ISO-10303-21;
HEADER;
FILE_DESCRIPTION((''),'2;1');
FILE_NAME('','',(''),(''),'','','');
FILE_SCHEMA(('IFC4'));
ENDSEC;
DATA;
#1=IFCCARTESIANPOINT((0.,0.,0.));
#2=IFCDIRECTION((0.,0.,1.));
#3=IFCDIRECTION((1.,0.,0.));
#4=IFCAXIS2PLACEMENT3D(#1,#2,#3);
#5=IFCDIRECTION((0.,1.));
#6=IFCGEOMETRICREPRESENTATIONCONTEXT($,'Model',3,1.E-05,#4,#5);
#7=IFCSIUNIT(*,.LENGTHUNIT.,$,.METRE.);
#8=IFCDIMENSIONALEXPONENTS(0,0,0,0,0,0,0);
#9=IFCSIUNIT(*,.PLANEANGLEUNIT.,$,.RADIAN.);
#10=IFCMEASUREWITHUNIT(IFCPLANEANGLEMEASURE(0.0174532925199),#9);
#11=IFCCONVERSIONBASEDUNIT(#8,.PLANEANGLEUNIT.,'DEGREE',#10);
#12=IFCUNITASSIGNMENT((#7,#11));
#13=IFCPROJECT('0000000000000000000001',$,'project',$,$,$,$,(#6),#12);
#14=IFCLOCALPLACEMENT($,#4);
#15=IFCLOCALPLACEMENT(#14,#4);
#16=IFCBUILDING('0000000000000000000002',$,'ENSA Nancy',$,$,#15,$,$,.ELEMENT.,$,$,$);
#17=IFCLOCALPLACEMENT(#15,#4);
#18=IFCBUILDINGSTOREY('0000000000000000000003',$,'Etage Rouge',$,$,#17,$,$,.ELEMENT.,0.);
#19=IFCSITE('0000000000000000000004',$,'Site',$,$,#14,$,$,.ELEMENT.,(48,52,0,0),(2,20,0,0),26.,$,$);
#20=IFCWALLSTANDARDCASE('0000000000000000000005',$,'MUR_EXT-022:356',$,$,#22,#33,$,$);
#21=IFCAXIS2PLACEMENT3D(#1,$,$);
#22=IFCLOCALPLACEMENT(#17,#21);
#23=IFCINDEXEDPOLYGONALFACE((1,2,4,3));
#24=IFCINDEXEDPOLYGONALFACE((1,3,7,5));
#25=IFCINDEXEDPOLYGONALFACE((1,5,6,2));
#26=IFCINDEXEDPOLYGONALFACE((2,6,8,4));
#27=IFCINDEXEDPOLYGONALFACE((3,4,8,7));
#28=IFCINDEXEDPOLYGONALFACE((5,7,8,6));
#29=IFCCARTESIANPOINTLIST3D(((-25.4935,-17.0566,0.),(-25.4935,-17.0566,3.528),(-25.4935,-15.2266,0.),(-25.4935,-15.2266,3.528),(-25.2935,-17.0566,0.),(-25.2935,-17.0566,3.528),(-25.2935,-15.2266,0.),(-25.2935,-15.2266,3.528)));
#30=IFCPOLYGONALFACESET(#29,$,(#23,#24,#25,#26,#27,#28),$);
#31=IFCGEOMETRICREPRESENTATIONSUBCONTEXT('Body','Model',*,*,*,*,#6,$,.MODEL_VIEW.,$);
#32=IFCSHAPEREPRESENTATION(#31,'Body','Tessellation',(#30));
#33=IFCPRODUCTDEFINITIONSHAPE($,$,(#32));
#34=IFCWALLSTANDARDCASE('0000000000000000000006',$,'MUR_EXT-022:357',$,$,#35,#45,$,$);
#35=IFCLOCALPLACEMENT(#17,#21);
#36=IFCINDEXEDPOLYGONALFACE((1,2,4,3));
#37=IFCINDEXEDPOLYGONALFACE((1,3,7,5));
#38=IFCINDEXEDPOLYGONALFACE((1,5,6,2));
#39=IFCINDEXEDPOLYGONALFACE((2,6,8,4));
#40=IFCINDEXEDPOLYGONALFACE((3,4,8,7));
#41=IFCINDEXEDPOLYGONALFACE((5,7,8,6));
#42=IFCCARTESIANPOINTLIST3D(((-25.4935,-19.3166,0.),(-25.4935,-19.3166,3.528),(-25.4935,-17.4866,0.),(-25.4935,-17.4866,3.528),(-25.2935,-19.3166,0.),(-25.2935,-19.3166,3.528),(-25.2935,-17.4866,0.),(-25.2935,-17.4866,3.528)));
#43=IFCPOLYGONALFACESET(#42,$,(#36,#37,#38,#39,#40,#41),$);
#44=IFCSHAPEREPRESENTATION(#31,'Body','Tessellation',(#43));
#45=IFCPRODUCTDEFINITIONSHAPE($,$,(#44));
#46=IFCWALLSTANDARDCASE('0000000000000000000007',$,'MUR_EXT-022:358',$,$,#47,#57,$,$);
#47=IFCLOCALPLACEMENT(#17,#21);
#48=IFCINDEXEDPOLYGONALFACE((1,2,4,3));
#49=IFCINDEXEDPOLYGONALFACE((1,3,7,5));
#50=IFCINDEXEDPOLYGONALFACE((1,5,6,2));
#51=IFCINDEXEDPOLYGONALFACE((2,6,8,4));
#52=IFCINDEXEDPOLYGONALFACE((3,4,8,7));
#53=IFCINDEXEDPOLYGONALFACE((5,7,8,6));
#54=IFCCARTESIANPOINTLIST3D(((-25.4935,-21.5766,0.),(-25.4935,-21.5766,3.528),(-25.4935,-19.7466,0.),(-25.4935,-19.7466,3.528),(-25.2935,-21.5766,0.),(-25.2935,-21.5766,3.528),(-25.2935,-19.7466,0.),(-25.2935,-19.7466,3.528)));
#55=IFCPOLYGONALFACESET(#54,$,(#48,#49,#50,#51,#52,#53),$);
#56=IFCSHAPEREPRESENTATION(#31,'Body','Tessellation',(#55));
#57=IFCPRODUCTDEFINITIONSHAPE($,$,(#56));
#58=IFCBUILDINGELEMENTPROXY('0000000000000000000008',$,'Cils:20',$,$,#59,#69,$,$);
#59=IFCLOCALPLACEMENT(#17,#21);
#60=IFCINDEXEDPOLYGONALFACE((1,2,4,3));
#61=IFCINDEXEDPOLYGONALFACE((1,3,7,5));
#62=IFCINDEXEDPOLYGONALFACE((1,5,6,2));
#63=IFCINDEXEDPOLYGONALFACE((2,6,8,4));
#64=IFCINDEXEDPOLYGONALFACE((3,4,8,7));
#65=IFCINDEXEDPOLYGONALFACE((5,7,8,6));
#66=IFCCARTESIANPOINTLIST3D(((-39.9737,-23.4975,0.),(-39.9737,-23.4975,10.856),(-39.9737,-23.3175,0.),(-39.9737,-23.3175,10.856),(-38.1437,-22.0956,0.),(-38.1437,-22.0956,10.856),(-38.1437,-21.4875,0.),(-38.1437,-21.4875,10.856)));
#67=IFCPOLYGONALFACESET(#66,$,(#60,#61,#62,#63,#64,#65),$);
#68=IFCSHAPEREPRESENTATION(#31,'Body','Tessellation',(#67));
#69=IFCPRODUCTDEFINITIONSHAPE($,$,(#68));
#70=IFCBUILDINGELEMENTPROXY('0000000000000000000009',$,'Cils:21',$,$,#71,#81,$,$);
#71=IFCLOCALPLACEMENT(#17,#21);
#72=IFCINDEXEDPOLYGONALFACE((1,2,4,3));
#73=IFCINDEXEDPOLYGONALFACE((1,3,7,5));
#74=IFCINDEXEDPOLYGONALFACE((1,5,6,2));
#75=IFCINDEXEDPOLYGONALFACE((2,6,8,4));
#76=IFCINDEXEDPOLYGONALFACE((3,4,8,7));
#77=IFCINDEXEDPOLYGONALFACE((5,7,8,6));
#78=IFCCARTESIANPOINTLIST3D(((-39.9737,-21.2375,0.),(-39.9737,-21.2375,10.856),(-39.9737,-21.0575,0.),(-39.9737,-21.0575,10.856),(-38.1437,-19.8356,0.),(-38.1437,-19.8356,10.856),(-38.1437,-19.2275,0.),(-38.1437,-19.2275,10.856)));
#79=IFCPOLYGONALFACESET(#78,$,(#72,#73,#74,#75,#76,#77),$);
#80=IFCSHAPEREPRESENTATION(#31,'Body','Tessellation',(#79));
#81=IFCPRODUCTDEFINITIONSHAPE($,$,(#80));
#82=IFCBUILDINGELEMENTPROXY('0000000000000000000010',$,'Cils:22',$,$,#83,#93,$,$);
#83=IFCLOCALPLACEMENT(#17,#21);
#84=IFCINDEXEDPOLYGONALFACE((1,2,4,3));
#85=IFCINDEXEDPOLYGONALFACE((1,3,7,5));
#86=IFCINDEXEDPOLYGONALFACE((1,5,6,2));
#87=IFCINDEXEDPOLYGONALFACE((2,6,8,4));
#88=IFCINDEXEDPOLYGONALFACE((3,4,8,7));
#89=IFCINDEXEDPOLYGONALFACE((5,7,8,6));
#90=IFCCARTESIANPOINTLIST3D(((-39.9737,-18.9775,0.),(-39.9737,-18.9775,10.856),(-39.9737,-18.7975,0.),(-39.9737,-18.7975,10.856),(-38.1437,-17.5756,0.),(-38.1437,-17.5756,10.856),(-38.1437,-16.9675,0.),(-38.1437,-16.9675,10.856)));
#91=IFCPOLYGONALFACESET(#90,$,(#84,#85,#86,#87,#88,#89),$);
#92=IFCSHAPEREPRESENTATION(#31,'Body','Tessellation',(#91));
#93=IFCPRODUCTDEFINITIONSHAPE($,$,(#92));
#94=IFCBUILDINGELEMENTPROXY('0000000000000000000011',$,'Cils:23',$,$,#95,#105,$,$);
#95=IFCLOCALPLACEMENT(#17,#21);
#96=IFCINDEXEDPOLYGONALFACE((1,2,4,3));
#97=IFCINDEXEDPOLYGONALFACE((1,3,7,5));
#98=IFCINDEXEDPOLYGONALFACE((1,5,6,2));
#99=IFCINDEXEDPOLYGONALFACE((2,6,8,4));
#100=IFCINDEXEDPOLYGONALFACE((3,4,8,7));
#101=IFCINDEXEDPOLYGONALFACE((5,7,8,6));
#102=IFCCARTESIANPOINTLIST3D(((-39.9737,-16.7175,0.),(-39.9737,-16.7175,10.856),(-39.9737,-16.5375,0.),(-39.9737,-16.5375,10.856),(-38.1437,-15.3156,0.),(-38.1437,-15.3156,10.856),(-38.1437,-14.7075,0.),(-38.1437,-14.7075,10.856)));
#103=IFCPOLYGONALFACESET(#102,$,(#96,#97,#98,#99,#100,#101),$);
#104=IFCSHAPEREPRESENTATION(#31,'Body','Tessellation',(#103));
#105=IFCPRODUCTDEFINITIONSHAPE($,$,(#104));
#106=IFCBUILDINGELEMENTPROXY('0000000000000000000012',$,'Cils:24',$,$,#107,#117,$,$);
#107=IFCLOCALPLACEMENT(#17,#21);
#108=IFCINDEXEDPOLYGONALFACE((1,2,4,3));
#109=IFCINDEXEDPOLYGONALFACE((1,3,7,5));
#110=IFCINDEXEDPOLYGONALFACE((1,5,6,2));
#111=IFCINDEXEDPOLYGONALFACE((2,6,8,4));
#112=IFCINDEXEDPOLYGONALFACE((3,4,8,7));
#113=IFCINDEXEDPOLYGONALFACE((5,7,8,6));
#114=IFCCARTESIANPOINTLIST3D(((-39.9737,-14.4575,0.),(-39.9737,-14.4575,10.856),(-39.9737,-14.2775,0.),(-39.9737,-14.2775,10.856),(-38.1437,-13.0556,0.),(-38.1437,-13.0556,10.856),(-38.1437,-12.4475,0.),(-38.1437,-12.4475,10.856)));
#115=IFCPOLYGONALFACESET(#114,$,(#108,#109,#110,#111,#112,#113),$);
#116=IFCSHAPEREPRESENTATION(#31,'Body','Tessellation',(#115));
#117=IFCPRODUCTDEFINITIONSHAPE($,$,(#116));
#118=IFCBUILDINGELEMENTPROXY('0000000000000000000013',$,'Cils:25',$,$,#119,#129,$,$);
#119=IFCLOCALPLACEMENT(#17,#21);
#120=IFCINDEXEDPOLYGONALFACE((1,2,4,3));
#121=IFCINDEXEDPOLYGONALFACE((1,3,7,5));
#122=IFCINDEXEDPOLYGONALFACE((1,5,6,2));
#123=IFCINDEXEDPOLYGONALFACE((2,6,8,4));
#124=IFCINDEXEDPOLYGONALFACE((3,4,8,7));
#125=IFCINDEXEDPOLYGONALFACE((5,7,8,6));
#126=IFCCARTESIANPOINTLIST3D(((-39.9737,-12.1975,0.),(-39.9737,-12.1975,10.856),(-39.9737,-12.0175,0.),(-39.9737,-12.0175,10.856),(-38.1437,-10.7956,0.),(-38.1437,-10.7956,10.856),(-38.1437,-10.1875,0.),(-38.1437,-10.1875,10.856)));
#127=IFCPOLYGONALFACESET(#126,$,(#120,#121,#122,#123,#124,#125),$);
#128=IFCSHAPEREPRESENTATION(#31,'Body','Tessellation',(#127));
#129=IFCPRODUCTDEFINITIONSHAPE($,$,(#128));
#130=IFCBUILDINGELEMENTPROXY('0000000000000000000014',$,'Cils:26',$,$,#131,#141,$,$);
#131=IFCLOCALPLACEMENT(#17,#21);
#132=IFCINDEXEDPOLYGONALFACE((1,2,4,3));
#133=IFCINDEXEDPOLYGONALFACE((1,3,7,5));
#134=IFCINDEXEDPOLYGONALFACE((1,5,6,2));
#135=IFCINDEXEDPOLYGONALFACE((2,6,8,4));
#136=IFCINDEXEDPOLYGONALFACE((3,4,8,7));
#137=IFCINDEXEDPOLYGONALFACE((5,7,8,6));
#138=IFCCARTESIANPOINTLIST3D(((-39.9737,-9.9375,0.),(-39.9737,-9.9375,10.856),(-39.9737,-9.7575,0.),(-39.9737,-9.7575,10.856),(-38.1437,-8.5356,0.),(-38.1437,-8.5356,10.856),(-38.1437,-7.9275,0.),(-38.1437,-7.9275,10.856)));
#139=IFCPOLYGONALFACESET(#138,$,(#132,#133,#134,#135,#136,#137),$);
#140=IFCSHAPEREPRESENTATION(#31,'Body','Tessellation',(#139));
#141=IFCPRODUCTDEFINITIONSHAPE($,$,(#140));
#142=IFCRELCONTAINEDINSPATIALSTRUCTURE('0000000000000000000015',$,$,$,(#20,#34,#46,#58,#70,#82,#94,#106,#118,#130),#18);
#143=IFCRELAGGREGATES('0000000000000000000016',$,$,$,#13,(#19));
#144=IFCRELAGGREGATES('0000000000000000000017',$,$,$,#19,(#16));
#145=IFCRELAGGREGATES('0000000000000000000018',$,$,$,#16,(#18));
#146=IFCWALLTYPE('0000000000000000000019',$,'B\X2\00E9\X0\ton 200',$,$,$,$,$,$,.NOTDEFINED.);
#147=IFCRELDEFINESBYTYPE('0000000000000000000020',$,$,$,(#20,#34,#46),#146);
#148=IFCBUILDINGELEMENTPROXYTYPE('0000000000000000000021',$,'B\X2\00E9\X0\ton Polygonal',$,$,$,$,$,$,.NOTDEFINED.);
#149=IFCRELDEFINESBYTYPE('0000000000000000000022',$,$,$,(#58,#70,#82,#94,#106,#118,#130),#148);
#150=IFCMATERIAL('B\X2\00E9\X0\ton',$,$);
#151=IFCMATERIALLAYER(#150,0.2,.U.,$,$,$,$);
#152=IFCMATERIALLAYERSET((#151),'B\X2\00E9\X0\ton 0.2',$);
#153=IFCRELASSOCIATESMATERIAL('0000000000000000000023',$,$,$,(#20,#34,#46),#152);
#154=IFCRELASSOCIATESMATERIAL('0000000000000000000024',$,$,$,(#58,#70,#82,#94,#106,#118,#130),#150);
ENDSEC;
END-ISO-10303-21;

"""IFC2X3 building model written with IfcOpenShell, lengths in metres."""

from ifc_helpers import new_model, entity, si_unit, converted_unit, direction, frame, origin_with_axes, place, context, subcontext, project, spatial, polyline, outline, extrude, material, layer, layer_set, layer_usage, type_object, element, save


model = new_model("IFC2X3")

# Units and contexts
model_context = context("Model", 3, precision=1e-05, world=origin_with_axes(), true_north=direction((0.0, 1.0)))
body_context = subcontext(model_context, "Body", "Model", "MODEL_VIEW")
ifc_project = project(units=[si_unit("LENGTHUNIT", "METRE"), converted_unit("PLANEANGLEUNIT", "DEGREE", entity("IfcPlaneAngleMeasure", 0.0174532925199), si_unit("PLANEANGLEUNIT", "RADIAN"), dimensions=[0, 0, 0, 0, 0, 0, 0])], contexts=[model_context])

# Site, building, storey
site_placement = place(None, origin_with_axes())
site = spatial("IfcSite", under=ifc_project, at=site_placement, Name="Site", CompositionType="ELEMENT", RefLatitude=(48, 52, 0, 0), RefLongitude=(2, 20, 0, 0), RefElevation=26.0)
building_placement = place(site_placement, origin_with_axes())
building = spatial("IfcBuilding", under=site, at=building_placement, Name="ENSA Nancy", CompositionType="ELEMENT")
storey_placement = place(building_placement, origin_with_axes())
storey = spatial("IfcBuildingStorey", under=building, at=storey_placement, Name="Etage Rouge", CompositionType="ELEMENT", Elevation=0.0)

# Walls
ifc_material_1 = material(Name="Béton")
ifc_layer_1 = layer(ifc_material_1, 0.2, ventilated="UNKNOWN")
ifc_layer_set_1 = layer_set([ifc_layer_1], Name="Béton 0.2")
wall_type_1 = type_object("IfcWallType", Name="Béton 200", PredefinedType="NOTDEFINED")
ifc_layer_usage_1 = layer_usage(ifc_layer_set_1, "AXIS2", "POSITIVE", -0.2)
wall_1_placement = place(storey_placement, frame((-25.2935, -15.2266, 0.0), z_axis=(0.0, 0.0, 1.0), x_axis=(0.0, -1.0, 0.0)))
element("IfcWallStandardCase", 1, at=wall_1_placement, inside=storey, type_object=wall_type_1, material=ifc_layer_usage_1, Name="MUR_EXT-022:356", context=body_context, shape_type="SweptSolid", body=[
    extrude(outline(polyline([(0.0, -0.2), (1.83, -0.2), (1.83, 0.0), (0.0, 0.0), (0.0, -0.2)])), origin_with_axes(), (0.0, 0.0, 1.0), 3.528),
])
ifc_layer_usage_2 = layer_usage(ifc_layer_set_1, "AXIS2", "POSITIVE", -0.2)
wall_2_placement = place(storey_placement, frame((-25.2935, -17.4866, 0.0), z_axis=(0.0, 0.0, 1.0), x_axis=(0.0, -1.0, 0.0)))
element("IfcWallStandardCase", 2, at=wall_2_placement, inside=storey, type_object=wall_type_1, material=ifc_layer_usage_2, Name="MUR_EXT-022:357", context=body_context, shape_type="SweptSolid", body=[
    extrude(outline(polyline([(0.0, -0.2), (1.83, -0.2), (1.83, 0.0), (0.0, 0.0), (0.0, -0.2)])), origin_with_axes(), (0.0, 0.0, 1.0), 3.528),
])
ifc_layer_usage_3 = layer_usage(ifc_layer_set_1, "AXIS2", "POSITIVE", -0.2)
wall_3_placement = place(storey_placement, frame((-25.2935, -19.7466, 0.0), z_axis=(0.0, 0.0, 1.0), x_axis=(0.0, -1.0, 0.0)))
element("IfcWallStandardCase", 3, at=wall_3_placement, inside=storey, type_object=wall_type_1, material=ifc_layer_usage_3, Name="MUR_EXT-022:358", context=body_context, shape_type="SweptSolid", body=[
    extrude(outline(polyline([(0.0, -0.2), (1.83, -0.2), (1.83, 0.0), (0.0, 0.0), (0.0, -0.2)])), origin_with_axes(), (0.0, 0.0, 1.0), 3.528),
])

# Building element proxies
building_element_proxy_type = type_object("IfcBuildingElementProxyType", Name="Béton Polygonal", PredefinedType="NOTDEFINED")
for number, where, z_axis, x_axis, name in (
    (4, (-38.1437, -21.4875, 0.0), (0.0, 0.0, 1.0), (-0.707107, -0.707107, 0.0), "Cils:20"),
    (5, (-38.1437, -19.2275, 0.0), (0.0, 0.0, 1.0), (-0.707107, -0.707107, 0.0), "Cils:21"),
    (6, (-38.1437, -16.9675, 0.0), (0.0, 0.0, 1.0), (-0.707107, -0.707107, 0.0), "Cils:22"),
    (7, (-38.1437, -14.7075, 0.0), (0.0, 0.0, 1.0), (-0.707107, -0.707107, 0.0), "Cils:23"),
    (8, (-38.1437, -12.4475, 0.0), (0.0, 0.0, 1.0), (-0.707107, -0.707107, 0.0), "Cils:24"),
    (9, (-38.1437, -10.1875, 0.0), (0.0, 0.0, 1.0), (-0.707107, -0.707107, 0.0), "Cils:25"),
    (10, (-38.1437, -7.9275, 0.0), (0.0, 0.0, 1.0), (-0.707107, -0.707107, 0.0), "Cils:26"),
):
    element("IfcBuildingElementProxy", number, at=place(storey_placement, frame(where, z_axis=z_axis, x_axis=x_axis)), inside=storey, type_object=building_element_proxy_type, material=ifc_material_1, Name=name, context=body_context, shape_type="SweptSolid", body=[
        extrude(outline(polyline([(0.0, 0.0), (2.588, 0.0), (2.7153, 0.1273), (0.43, 0.43), (0.0, 0.0)])), origin_with_axes(), (0.0, 0.0, 1.0), 10.856),
    ])

save(model, "model.ifc")
